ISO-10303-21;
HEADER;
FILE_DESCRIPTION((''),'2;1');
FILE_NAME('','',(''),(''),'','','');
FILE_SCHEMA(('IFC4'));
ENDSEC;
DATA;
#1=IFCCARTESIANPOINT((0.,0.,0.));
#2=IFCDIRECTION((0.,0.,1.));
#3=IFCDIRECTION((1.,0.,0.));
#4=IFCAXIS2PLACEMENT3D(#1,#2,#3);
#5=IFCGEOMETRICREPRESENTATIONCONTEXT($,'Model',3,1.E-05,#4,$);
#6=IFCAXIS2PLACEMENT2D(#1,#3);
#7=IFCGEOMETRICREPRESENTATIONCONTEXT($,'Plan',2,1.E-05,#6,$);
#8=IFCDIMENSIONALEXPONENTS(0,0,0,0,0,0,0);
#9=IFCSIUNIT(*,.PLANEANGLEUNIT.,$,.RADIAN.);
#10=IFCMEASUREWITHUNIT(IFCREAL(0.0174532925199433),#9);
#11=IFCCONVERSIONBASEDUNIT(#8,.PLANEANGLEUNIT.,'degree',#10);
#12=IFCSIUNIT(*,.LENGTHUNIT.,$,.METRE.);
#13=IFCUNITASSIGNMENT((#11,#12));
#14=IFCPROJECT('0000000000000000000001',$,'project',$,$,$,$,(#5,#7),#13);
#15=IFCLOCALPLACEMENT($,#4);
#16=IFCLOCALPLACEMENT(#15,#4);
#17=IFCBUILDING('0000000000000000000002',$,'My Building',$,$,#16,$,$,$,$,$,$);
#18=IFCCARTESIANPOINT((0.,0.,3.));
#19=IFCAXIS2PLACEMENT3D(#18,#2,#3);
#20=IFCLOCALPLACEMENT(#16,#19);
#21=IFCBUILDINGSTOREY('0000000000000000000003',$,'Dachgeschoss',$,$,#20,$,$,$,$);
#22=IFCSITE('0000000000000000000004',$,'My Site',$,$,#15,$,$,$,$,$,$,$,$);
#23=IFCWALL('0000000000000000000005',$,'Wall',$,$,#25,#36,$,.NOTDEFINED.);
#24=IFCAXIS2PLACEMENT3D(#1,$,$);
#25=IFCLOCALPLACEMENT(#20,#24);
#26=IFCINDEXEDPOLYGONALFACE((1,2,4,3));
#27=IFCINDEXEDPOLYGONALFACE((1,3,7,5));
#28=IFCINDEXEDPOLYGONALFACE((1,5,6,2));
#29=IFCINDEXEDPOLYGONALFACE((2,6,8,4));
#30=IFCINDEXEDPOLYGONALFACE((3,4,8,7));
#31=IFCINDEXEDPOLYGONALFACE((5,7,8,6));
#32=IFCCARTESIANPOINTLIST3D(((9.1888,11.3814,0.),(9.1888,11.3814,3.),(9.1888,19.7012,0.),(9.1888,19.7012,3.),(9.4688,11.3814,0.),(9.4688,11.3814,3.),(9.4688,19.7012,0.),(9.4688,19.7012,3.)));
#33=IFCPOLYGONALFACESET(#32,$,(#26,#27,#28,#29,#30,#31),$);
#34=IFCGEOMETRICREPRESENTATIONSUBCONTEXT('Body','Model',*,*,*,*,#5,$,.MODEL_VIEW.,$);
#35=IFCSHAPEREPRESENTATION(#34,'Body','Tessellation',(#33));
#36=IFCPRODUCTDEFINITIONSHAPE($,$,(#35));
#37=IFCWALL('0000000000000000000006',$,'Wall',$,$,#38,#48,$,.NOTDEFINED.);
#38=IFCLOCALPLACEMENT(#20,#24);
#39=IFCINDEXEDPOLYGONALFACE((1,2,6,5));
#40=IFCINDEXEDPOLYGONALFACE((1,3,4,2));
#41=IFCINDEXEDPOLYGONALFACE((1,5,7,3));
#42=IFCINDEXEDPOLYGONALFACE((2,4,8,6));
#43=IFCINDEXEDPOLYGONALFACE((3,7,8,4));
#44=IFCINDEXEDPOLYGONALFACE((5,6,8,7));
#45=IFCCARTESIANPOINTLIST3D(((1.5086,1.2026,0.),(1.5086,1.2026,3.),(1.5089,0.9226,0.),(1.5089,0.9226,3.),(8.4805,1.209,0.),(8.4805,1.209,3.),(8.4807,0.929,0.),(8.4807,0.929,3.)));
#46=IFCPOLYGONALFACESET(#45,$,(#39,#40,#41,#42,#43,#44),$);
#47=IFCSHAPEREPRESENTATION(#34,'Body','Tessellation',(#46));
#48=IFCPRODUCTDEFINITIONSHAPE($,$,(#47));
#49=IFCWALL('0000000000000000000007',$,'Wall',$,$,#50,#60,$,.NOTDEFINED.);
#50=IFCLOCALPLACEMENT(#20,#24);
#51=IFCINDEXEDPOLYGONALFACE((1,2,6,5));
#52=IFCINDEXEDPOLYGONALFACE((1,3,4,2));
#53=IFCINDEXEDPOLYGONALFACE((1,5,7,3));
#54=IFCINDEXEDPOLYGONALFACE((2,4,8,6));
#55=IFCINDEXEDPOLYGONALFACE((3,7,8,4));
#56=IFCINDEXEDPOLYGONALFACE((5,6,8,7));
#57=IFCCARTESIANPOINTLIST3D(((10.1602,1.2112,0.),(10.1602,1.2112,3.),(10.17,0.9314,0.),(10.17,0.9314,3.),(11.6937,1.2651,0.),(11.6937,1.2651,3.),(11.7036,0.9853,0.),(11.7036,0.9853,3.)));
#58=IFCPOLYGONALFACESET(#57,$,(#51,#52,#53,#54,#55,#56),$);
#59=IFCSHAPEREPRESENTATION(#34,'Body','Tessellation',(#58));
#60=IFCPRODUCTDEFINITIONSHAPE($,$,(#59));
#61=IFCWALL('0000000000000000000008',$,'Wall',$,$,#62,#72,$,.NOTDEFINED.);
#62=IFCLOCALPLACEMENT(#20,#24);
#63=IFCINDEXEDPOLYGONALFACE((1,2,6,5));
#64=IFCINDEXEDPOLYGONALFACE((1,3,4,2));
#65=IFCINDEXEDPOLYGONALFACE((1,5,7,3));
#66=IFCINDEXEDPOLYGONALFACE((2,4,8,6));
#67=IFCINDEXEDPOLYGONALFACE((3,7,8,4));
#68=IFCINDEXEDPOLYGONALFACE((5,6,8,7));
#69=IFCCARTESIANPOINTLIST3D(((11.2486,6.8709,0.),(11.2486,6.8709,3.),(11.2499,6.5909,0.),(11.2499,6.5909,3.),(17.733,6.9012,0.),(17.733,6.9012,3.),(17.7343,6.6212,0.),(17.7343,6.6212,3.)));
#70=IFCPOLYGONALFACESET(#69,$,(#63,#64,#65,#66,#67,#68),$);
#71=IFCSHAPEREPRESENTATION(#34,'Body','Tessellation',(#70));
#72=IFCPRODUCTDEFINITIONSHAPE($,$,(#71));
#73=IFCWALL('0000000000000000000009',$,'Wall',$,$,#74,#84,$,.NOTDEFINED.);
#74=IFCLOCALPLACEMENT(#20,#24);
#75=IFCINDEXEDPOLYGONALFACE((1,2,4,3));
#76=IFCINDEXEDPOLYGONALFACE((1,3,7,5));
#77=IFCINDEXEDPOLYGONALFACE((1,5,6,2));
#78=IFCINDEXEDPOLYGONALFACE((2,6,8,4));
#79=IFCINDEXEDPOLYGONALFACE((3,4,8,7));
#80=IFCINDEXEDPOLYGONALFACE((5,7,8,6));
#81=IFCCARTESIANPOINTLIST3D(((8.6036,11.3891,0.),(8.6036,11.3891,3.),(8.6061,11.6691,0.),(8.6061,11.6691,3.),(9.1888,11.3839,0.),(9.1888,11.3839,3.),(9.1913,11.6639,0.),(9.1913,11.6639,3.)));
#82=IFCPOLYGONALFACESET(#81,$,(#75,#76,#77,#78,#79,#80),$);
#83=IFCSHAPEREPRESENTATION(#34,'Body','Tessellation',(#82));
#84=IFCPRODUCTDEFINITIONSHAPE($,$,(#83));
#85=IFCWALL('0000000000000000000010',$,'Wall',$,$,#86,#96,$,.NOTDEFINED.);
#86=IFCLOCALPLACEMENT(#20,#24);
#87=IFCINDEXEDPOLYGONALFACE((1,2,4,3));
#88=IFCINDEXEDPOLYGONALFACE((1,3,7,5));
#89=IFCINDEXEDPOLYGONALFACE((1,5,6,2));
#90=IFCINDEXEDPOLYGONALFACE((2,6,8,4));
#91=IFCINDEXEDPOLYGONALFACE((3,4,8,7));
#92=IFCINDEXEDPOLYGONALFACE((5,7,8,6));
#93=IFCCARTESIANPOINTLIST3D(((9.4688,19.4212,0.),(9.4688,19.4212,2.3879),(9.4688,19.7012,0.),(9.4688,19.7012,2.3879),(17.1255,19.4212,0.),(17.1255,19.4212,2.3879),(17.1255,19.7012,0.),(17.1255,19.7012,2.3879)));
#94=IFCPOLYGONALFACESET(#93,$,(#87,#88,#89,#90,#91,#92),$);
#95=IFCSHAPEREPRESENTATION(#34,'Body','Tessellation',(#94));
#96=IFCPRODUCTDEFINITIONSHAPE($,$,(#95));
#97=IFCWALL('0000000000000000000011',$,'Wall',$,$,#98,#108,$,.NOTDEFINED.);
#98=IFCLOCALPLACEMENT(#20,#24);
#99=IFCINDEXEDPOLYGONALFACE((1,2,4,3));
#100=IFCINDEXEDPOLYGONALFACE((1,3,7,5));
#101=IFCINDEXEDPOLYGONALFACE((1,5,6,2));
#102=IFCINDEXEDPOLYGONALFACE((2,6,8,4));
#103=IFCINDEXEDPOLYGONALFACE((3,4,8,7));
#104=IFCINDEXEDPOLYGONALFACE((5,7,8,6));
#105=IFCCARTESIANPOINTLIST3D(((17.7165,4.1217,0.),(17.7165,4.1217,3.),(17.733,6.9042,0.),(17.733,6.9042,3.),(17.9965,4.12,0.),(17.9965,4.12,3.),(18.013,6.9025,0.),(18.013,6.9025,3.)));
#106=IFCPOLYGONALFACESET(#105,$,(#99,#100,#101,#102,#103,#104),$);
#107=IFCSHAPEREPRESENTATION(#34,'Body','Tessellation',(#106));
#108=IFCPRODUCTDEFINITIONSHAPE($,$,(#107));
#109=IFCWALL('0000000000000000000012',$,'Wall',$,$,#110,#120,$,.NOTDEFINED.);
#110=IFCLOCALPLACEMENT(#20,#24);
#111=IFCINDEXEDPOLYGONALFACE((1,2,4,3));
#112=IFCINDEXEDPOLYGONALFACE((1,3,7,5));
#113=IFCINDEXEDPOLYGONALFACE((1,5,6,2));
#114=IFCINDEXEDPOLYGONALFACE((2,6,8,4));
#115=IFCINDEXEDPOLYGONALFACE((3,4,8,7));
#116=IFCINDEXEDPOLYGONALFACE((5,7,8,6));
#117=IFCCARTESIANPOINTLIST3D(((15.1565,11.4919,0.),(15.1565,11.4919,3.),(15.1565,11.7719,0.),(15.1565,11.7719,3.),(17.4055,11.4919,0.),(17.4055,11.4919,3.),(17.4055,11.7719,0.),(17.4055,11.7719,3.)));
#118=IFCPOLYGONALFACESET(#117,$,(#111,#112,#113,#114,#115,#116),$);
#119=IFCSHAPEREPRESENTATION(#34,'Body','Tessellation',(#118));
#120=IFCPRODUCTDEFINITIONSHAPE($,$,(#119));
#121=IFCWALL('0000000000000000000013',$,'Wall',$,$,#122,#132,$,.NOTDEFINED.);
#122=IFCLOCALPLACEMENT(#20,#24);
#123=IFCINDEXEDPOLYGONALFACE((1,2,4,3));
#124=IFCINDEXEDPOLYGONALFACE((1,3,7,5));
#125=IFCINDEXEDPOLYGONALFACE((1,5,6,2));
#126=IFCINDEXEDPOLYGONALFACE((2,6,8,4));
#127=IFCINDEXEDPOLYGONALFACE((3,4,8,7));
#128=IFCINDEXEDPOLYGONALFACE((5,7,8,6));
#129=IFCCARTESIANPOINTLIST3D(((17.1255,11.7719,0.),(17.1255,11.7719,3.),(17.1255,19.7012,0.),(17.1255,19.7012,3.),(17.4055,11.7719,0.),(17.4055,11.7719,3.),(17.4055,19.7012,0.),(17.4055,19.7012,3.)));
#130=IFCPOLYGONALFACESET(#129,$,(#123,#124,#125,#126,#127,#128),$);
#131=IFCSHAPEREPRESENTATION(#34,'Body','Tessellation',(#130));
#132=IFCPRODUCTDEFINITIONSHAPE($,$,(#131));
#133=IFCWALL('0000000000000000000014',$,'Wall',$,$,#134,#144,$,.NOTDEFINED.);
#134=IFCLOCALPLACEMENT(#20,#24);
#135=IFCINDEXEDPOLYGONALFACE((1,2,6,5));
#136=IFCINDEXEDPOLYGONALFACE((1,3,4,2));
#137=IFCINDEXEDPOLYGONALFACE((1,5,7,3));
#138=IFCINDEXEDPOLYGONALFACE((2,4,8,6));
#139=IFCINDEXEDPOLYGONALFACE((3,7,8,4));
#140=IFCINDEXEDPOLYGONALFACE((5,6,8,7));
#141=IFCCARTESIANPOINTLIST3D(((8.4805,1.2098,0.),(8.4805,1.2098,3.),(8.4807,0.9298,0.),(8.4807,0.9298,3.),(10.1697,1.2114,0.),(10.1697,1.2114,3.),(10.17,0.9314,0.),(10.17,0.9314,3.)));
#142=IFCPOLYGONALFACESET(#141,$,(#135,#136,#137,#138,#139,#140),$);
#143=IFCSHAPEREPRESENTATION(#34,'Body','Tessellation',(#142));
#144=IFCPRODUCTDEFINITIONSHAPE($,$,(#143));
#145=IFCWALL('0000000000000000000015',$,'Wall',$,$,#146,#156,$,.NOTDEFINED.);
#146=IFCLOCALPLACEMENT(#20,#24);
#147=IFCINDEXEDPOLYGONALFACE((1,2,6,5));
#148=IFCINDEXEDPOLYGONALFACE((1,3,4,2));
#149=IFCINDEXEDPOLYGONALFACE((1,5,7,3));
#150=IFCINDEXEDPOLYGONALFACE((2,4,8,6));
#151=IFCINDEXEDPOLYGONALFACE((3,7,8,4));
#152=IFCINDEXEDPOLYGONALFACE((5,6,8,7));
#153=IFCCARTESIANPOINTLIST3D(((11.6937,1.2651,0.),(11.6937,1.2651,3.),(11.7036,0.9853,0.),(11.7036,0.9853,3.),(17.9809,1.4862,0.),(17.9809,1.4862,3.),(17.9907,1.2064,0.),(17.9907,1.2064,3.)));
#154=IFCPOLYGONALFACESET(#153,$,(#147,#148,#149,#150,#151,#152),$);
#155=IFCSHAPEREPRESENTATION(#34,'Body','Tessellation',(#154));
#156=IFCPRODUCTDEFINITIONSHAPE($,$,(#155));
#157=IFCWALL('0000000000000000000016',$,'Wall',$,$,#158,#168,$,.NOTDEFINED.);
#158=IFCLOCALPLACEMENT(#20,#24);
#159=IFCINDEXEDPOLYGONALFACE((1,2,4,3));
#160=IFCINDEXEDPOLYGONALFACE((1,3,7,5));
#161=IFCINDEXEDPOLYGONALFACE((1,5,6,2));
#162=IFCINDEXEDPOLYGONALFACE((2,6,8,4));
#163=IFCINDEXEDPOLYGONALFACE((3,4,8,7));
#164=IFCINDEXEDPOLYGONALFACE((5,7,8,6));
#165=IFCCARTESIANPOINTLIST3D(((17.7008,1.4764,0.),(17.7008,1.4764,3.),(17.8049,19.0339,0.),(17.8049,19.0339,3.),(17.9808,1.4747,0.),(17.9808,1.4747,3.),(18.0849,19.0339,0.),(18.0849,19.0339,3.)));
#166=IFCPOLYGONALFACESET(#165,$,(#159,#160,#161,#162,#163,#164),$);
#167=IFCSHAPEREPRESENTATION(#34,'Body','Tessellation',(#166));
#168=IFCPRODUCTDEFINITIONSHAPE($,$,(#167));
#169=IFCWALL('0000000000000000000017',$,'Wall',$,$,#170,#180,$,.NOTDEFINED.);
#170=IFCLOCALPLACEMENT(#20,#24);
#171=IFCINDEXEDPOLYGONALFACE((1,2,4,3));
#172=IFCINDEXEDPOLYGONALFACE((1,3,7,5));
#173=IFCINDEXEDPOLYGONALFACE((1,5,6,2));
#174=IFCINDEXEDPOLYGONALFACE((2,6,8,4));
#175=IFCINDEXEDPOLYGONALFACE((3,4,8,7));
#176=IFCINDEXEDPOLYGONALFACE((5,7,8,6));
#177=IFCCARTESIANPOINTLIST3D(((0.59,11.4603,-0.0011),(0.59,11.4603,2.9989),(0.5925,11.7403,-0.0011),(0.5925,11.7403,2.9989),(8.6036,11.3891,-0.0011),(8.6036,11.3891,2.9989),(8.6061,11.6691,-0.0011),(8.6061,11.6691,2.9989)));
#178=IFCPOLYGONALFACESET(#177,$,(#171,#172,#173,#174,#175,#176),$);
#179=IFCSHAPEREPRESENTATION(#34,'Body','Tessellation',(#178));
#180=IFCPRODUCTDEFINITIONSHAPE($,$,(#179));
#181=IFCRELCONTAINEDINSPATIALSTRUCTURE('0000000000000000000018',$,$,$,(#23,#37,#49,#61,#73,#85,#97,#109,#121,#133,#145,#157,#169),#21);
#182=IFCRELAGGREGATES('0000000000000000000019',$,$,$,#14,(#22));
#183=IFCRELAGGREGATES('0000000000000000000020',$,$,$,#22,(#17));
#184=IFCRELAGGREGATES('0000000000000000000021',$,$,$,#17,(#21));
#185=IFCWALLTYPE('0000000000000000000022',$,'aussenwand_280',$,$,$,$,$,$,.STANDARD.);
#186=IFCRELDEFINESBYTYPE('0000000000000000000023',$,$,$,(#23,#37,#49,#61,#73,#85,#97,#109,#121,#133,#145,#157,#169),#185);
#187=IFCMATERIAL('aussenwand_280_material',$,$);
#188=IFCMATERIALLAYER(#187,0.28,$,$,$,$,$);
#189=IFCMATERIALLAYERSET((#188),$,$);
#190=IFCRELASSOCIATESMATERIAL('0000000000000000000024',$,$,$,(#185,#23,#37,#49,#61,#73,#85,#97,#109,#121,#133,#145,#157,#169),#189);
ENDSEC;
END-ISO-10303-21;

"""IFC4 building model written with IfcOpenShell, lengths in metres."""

from ifc_helpers import new_model, entity, si_unit, converted_unit, frame, frame_2d, origin_with_axes, place, context, subcontext, project, spatial, indexed_curve, outline, extrude, clip, halfspace, material, layer, layer_set, layer_usage, type_object, element, save


model = new_model("IFC4")

# Units and contexts
model_context = context("Model", 3, precision=1e-05, world=origin_with_axes())
plan_context = context("Plan", 2, precision=1e-05, world=frame_2d((0.0, 0.0, 0.0), x_axis=(1.0, 0.0, 0.0)))
body_context = subcontext(model_context, "Body", "Model", "MODEL_VIEW")
ifc_project = project(units=[converted_unit("PLANEANGLEUNIT", "degree", entity("IfcReal", 0.0174532925199433), si_unit("PLANEANGLEUNIT", "RADIAN"), dimensions=[0, 0, 0, 0, 0, 0, 0]), si_unit("LENGTHUNIT", "METRE")], contexts=[model_context, plan_context])

# Site, building, storey
site_placement = place(None, origin_with_axes())
site = spatial("IfcSite", under=ifc_project, at=site_placement, Name="My Site")
building_placement = place(site_placement, origin_with_axes())
building = spatial("IfcBuilding", under=site, at=building_placement, Name="My Building")
storey_placement = place(building_placement, frame((0.0, 0.0, 3.0), z_axis=(0.0, 0.0, 1.0), x_axis=(1.0, 0.0, 0.0)))
storey = spatial("IfcBuildingStorey", under=building, at=storey_placement, Name="Dachgeschoss")

# Walls
ifc_material = material(Name="aussenwand_280_material")
ifc_layer = layer(ifc_material, 0.28)
ifc_layer_set = layer_set([ifc_layer])
ifc_layer_usage_1 = layer_usage(ifc_layer_set, "AXIS2", "POSITIVE", 0.0)
wall_type = type_object("IfcWallType", Name="aussenwand_280", PredefinedType="STANDARD", material=ifc_layer_set)
wall_1_placement = place(storey_placement, frame((9.1888, 19.7012, 0.0), z_axis=(0.0, 0.0, 1.0), x_axis=(0.0, -1.0, 0.0)))
element("IfcWall", 1, at=wall_1_placement, inside=storey, type_object=wall_type, material=ifc_layer_usage_1, Name="Wall", PredefinedType="NOTDEFINED", context=body_context, shape_type="SweptSolid", body=[
    extrude(outline(indexed_curve([(0.0, 0.0), (0.0, 0.28), (8.3198, 0.28), (8.3198, 0.0), (0.0, 0.0)], self_intersect=False)), origin_with_axes(), (0.0, 0.0, 1.0), 3.0),
])
ifc_layer_usage_2 = layer_usage(ifc_layer_set, "AXIS2", "POSITIVE", 0.0)
wall_2_placement = place(storey_placement, frame((1.5089, 0.9226, 0.0), z_axis=(0.0, 0.0, 1.0), x_axis=(1.0, 0.000923, 0.0)))
element("IfcWall", 2, at=wall_2_placement, inside=storey, type_object=wall_type, material=ifc_layer_usage_2, Name="Wall", PredefinedType="NOTDEFINED", context=body_context, shape_type="SweptSolid", body=[
    extrude(outline(indexed_curve([(0.0, 0.0), (0.0, 0.28), (6.9719, 0.28), (6.9719, 0.0), (0.0, 0.0)], self_intersect=False)), origin_with_axes(), (0.0, 0.0, 1.0), 3.0),
])
ifc_layer_usage_3 = layer_usage(ifc_layer_set, "AXIS2", "POSITIVE", 0.0)
wall_3_placement = place(storey_placement, frame((10.17, 0.9314, 0.0), z_axis=(0.0, 0.0, 1.0), x_axis=(0.999382, 0.035142, 0.0)))
element("IfcWall", 3, at=wall_3_placement, inside=storey, type_object=wall_type, material=ifc_layer_usage_3, Name="Wall", PredefinedType="NOTDEFINED", context=body_context, shape_type="SweptSolid", body=[
    extrude(outline(indexed_curve([(0.0, 0.0), (0.0, 0.28), (1.5345, 0.28), (1.5345, 0.0), (0.0, 0.0)], self_intersect=False)), origin_with_axes(), (0.0, 0.0, 1.0), 3.0),
])
ifc_layer_usage_4 = layer_usage(ifc_layer_set, "AXIS2", "POSITIVE", 0.0)
wall_4_placement = place(storey_placement, frame((17.733, 6.9012, 0.0), z_axis=(0.0, 0.0, 1.0), x_axis=(-0.999989, -0.004672, 0.0)))
element("IfcWall", 4, at=wall_4_placement, inside=storey, type_object=wall_type, material=ifc_layer_usage_4, Name="Wall", PredefinedType="NOTDEFINED", context=body_context, shape_type="SweptSolid", body=[
    extrude(outline(indexed_curve([(0.0, 0.0), (0.0, 0.28), (6.4845, 0.28), (6.4845, 0.0), (0.0, 0.0)], self_intersect=False)), origin_with_axes(), (0.0, 0.0, 1.0), 3.0),
])
ifc_layer_usage_5 = layer_usage(ifc_layer_set, "AXIS2", "POSITIVE", 0.0)
wall_5_placement = place(storey_placement, frame((9.1913, 11.6639, 0.0), z_axis=(0.0, 0.0, 1.0), x_axis=(-0.999961, 0.008884, 0.0)))
element("IfcWall", 5, at=wall_5_placement, inside=storey, type_object=wall_type, material=ifc_layer_usage_5, Name="Wall", PredefinedType="NOTDEFINED", context=body_context, shape_type="SweptSolid", body=[
    extrude(outline(indexed_curve([(0.0, 0.0), (0.0, 0.28), (0.5852, 0.28), (0.5852, 0.0), (0.0, 0.0)], self_intersect=False)), origin_with_axes(), (0.0, 0.0, 1.0), 3.0),
])
ifc_layer_usage_6 = layer_usage(ifc_layer_set, "AXIS2", "POSITIVE", 0.0)
wall_6_placement = place(storey_placement, frame((9.4688, 19.4212, 0.0), z_axis=(0.0, 0.0, 1.0), x_axis=(1.0, 0.0, 0.0)))
element("IfcWall", 6, at=wall_6_placement, inside=storey, type_object=wall_type, material=ifc_layer_usage_6, Name="Wall", PredefinedType="NOTDEFINED", context=body_context, shape_type="Clipping", body=[
    clip(extrude(outline(indexed_curve([(0.0, 0.0), (0.0, 0.28), (7.6567, 0.28), (7.6567, 0.0), (0.0, 0.0)], self_intersect=False)), origin_with_axes(), (0.0, 0.0, 1.0), 2.3879), halfspace(frame((0.0, 0.0, -0.6121), z_axis=(0.0, 0.0, 1.0), x_axis=(1.0, 0.0, 0.0)), False)),
])
ifc_layer_usage_7 = layer_usage(ifc_layer_set, "AXIS2", "POSITIVE", 0.0)
wall_7_placement = place(storey_placement, frame((17.733, 6.9042, 0.0), z_axis=(0.0, 0.0, 1.0), x_axis=(-0.005929, -0.999982, 0.0)))
element("IfcWall", 7, at=wall_7_placement, inside=storey, type_object=wall_type, material=ifc_layer_usage_7, Name="Wall", PredefinedType="NOTDEFINED", context=body_context, shape_type="SweptSolid", body=[
    extrude(outline(indexed_curve([(0.0, 0.0), (0.0, 0.28), (2.7826, 0.28), (2.7826, 0.0), (0.0, 0.0)], self_intersect=False)), origin_with_axes(), (0.0, 0.0, 1.0), 3.0),
])
ifc_layer_usage_8 = layer_usage(ifc_layer_set, "AXIS2", "POSITIVE", 0.0)
wall_8_placement = place(storey_placement, frame((15.1565, 11.4919, 0.0), z_axis=(0.0, 0.0, 1.0), x_axis=(1.0, 0.0, 0.0)))
element("IfcWall", 8, at=wall_8_placement, inside=storey, type_object=wall_type, material=ifc_layer_usage_8, Name="Wall", PredefinedType="NOTDEFINED", context=body_context, shape_type="SweptSolid", body=[
    extrude(outline(indexed_curve([(0.0, 0.0), (0.0, 0.28), (2.249, 0.28), (2.249, 0.0), (0.0, 0.0)], self_intersect=False)), origin_with_axes(), (0.0, 0.0, 1.0), 3.0),
])
ifc_layer_usage_9 = layer_usage(ifc_layer_set, "AXIS2", "POSITIVE", 0.0)
wall_9_placement = place(storey_placement, frame((17.1255, 19.7012, 0.0), z_axis=(0.0, 0.0, 1.0), x_axis=(0.0, -1.0, 0.0)))
element("IfcWall", 9, at=wall_9_placement, inside=storey, type_object=wall_type, material=ifc_layer_usage_9, Name="Wall", PredefinedType="NOTDEFINED", context=body_context, shape_type="SweptSolid", body=[
    extrude(outline(indexed_curve([(0.0, 0.0), (0.0, 0.28), (7.9293, 0.28), (7.9293, 0.0), (0.0, 0.0)], self_intersect=False)), origin_with_axes(), (0.0, 0.0, 1.0), 3.0),
])
ifc_layer_usage_10 = layer_usage(ifc_layer_set, "AXIS2", "POSITIVE", 0.0)
wall_10_placement = place(storey_placement, frame((8.4807, 0.9298, 0.0), z_axis=(0.0, 0.0, 1.0), x_axis=(1.0, 0.000923, 0.0)))
element("IfcWall", 10, at=wall_10_placement, inside=storey, type_object=wall_type, material=ifc_layer_usage_10, Name="Wall", PredefinedType="NOTDEFINED", context=body_context, shape_type="SweptSolid", body=[
    extrude(outline(indexed_curve([(0.0, 0.0), (0.0, 0.28), (1.6893, 0.28), (1.6893, 0.0), (0.0, 0.0)], self_intersect=False)), origin_with_axes(), (0.0, 0.0, 1.0), 3.0),
])
ifc_layer_usage_11 = layer_usage(ifc_layer_set, "AXIS2", "POSITIVE", 0.0)
wall_11_placement = place(storey_placement, frame((11.7036, 0.9853, 0.0), z_axis=(0.0, 0.0, 1.0), x_axis=(0.999382, 0.035142, 0.0)))
element("IfcWall", 11, at=wall_11_placement, inside=storey, type_object=wall_type, material=ifc_layer_usage_11, Name="Wall", PredefinedType="NOTDEFINED", context=body_context, shape_type="SweptSolid", body=[
    extrude(outline(indexed_curve([(0.0, 0.0), (0.0, 0.28), (6.291, 0.28), (6.291, 0.0), (0.0, 0.0)], self_intersect=False)), origin_with_axes(), (0.0, 0.0, 1.0), 3.0),
])
ifc_layer_usage_12 = layer_usage(ifc_layer_set, "AXIS2", "POSITIVE", 0.0)
wall_12_placement = place(storey_placement, frame((17.8049, 19.0355, 0.0), z_axis=(0.0, 0.0, 1.0), x_axis=(-0.005929, -0.999982, 0.0)))
element("IfcWall", 12, at=wall_12_placement, inside=storey, type_object=wall_type, material=ifc_layer_usage_12, Name="Wall", PredefinedType="NOTDEFINED", context=body_context, shape_type="Clipping", body=[
    clip(extrude(outline(indexed_curve([(0.0, 0.0), (0.0, 0.28), (17.5595, 0.28), (17.5595, 0.0), (0.0, 0.0)], self_intersect=False)), origin_with_axes(), (0.0, 0.0, 1.0), 3.0), halfspace(frame((0.0017, 0.0, -3.0), z_axis=(-0.839993, -0.00498, 0.0), x_axis=(-0.00166, 0.279998, 0.0)), False)),
])
ifc_layer_usage_13 = layer_usage(ifc_layer_set, "AXIS2", "POSITIVE", 0.0)
wall_13_placement = place(storey_placement, frame((8.6061, 11.6691, -0.0011), z_axis=(0.0, 0.0, 1.0), x_axis=(-0.999961, 0.008884, 0.0)))
element("IfcWall", 13, at=wall_13_placement, inside=storey, type_object=wall_type, material=ifc_layer_usage_13, Name="Wall", PredefinedType="NOTDEFINED", context=body_context, shape_type="SweptSolid", body=[
    extrude(outline(indexed_curve([(0.0, 0.0), (0.0, 0.28), (8.0139, 0.28), (8.0139, 0.0), (0.0, 0.0)], self_intersect=False)), origin_with_axes(), (0.0, 0.0, 1.0), 3.0),
])

save(model, "model.ifc")
